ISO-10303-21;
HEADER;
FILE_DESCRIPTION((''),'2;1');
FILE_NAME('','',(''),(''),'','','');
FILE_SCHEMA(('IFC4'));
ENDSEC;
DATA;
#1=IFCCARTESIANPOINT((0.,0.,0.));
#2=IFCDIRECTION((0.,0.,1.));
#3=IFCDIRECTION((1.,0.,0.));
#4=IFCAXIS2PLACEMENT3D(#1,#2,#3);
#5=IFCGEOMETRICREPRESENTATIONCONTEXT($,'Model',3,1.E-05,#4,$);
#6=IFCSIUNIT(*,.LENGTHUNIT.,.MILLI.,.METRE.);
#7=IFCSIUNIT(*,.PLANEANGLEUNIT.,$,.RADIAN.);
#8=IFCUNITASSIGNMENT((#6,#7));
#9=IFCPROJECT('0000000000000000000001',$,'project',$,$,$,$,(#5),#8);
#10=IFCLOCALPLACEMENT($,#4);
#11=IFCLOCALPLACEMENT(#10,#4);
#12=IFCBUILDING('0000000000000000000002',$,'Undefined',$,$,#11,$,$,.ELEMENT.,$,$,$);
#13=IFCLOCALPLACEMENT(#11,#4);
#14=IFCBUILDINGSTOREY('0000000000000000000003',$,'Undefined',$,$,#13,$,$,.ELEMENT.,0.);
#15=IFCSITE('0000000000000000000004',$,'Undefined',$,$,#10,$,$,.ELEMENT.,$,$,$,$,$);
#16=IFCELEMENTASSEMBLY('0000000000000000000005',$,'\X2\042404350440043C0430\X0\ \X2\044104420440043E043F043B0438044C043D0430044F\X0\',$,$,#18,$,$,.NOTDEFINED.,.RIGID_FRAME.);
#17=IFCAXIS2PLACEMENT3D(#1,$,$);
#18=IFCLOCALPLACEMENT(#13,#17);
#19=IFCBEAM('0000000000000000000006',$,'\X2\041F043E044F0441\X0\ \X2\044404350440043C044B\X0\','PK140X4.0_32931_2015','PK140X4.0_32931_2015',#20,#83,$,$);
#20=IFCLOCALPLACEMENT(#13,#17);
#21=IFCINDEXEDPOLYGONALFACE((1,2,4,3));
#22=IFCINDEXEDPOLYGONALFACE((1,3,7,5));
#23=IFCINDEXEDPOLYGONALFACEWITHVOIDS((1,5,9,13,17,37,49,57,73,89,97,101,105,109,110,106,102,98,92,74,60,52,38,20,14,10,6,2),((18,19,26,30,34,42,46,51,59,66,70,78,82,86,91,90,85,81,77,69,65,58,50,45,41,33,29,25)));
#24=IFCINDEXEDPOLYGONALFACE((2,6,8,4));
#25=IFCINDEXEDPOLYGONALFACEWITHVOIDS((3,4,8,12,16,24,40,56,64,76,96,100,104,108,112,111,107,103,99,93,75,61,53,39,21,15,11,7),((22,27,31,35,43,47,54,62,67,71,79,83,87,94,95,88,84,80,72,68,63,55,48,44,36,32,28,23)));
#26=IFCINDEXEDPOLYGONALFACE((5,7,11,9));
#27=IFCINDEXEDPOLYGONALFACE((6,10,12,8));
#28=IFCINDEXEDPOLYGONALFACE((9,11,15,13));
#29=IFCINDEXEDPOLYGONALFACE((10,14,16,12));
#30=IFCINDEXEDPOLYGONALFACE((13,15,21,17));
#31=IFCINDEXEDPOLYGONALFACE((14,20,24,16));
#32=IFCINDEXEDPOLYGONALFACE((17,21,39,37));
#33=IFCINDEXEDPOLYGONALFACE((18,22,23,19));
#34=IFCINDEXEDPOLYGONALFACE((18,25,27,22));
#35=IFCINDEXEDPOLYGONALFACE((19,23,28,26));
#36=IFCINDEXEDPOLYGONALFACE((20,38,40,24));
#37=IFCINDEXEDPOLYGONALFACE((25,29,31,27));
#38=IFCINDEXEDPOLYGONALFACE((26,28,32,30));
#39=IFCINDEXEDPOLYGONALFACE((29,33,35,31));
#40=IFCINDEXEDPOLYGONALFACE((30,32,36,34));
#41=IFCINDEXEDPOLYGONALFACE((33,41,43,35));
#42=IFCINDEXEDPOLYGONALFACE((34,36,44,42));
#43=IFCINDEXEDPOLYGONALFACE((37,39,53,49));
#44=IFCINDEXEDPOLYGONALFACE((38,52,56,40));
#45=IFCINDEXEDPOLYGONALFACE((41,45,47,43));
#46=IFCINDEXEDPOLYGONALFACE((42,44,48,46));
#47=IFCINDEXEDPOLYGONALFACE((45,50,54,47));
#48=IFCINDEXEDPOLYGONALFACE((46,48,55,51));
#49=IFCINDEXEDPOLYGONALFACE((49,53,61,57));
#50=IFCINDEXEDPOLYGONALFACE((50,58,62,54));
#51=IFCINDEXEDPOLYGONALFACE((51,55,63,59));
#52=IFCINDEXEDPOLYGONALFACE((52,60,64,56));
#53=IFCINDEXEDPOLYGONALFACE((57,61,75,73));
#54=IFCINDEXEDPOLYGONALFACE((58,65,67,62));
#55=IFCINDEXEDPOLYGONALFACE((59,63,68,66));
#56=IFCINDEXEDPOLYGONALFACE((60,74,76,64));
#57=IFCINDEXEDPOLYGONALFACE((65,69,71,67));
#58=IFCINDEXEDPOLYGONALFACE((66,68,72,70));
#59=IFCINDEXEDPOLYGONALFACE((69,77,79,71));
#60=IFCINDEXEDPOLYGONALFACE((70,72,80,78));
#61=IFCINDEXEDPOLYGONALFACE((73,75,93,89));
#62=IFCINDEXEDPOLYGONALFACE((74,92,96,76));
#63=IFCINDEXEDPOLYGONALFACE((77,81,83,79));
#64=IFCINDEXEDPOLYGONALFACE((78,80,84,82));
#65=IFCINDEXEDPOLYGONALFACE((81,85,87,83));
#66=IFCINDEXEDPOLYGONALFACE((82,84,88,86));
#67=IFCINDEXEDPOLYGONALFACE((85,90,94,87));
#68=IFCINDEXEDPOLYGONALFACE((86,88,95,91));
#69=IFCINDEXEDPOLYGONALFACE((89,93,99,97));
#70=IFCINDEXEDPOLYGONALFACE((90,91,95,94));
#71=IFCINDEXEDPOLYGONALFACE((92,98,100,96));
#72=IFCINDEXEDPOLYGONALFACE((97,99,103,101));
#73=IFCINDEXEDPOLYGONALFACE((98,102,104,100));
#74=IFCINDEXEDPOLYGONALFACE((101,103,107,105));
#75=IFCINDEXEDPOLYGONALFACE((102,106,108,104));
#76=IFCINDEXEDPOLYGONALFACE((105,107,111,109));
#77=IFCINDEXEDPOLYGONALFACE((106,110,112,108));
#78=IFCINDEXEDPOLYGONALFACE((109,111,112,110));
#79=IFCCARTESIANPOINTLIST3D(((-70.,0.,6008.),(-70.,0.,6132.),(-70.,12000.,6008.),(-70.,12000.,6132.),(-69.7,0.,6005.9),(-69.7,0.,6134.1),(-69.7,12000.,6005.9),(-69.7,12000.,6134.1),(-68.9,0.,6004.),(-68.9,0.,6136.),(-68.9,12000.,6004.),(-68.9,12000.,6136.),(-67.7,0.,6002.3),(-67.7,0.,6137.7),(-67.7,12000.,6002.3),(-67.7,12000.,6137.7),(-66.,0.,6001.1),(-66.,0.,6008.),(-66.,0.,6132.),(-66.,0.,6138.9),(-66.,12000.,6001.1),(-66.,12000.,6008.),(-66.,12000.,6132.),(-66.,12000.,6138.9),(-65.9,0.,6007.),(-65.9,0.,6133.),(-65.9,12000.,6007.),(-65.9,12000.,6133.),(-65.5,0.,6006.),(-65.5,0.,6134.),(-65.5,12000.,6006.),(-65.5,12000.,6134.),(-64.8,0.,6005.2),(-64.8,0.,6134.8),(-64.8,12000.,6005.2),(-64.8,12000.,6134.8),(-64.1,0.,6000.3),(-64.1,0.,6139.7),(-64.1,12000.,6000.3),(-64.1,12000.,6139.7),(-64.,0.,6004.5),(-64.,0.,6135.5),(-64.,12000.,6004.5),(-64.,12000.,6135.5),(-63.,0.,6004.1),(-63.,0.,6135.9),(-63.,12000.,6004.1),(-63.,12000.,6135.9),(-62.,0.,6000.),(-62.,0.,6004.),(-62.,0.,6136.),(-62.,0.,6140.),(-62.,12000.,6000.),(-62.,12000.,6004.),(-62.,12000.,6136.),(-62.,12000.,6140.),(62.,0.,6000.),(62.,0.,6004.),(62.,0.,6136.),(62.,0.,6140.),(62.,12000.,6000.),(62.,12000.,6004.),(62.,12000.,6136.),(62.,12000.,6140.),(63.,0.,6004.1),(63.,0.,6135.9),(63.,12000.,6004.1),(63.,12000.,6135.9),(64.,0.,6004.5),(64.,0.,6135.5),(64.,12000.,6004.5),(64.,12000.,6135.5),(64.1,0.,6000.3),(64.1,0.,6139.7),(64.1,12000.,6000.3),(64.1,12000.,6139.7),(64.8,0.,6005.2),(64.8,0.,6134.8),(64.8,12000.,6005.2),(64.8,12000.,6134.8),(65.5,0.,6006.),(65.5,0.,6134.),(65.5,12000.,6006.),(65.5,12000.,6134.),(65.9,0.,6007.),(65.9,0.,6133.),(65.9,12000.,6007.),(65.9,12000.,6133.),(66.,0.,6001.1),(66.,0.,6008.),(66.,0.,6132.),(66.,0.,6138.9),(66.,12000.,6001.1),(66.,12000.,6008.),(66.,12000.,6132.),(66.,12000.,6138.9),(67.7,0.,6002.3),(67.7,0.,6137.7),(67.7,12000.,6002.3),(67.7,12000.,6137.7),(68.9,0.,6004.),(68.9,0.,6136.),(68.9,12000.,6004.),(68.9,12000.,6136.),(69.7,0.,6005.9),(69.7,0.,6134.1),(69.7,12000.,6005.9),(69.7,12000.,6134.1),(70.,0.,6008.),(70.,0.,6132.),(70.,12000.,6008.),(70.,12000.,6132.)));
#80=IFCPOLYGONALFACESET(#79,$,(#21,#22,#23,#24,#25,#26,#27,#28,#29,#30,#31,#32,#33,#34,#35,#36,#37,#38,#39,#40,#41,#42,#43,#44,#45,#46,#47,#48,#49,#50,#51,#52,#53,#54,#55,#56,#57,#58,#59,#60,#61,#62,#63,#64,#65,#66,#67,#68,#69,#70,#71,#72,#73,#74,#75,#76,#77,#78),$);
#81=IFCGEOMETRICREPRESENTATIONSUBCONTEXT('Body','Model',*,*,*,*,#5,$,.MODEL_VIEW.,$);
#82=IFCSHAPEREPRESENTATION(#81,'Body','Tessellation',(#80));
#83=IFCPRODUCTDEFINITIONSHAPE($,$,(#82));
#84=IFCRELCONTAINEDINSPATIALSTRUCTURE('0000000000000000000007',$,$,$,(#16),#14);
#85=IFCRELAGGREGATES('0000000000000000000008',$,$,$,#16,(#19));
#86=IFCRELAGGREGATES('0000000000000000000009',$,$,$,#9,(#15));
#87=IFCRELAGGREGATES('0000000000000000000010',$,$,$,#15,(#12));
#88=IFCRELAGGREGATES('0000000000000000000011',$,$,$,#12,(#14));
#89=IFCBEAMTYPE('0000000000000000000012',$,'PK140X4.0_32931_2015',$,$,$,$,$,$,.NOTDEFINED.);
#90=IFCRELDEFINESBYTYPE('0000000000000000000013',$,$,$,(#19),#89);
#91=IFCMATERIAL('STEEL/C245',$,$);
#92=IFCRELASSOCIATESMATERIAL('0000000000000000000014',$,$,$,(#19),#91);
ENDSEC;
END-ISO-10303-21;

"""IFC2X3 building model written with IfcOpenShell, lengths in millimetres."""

from ifc_helpers import new_model, si_unit, frame, origin_with_axes, origin_2d_with_axis, place, context, subcontext, project, spatial, hollow_rectangle, extrude, material, type_object, element, aggregate, save


model = new_model("IFC2X3")

# Units and contexts
model_context = context("Model", 3, precision=1e-05, world=origin_with_axes())
body_context = subcontext(model_context, "Body", "Model", "MODEL_VIEW")
ifc_project = project(units=[si_unit("LENGTHUNIT", "METRE", prefix="MILLI"), si_unit("PLANEANGLEUNIT", "RADIAN")], contexts=[model_context])

# Site, building, storey
site_placement = place(None, origin_with_axes())
site = spatial("IfcSite", under=ifc_project, at=site_placement, Name="Undefined", CompositionType="ELEMENT")
building_placement = place(site_placement, origin_with_axes())
building = spatial("IfcBuilding", under=site, at=building_placement, Name="Undefined", CompositionType="ELEMENT")
storey_placement = place(building_placement, origin_with_axes())
storey = spatial("IfcBuildingStorey", under=building, at=storey_placement, Name="Undefined", CompositionType="ELEMENT", Elevation=0.0)

# Shared definitions
ifc_material = material(Name="STEEL/C245")

# Element assembly
assembly_1_placement = place(storey_placement, origin_with_axes())
assembly_1 = element("IfcElementAssembly", 1, at=assembly_1_placement, inside=storey, Name="Ферма строплиьная", AssemblyPlace="NOTDEFINED", PredefinedType="RIGID_FRAME")

# Beam
beam_type_1 = type_object("IfcBeamType", Name="PK140X4.0_32931_2015", PredefinedType="NOTDEFINED")
beam_1_placement = place(assembly_1_placement, frame((0.0, 0.0, 6070.0), z_axis=(0.0, 0.0, 1.0), x_axis=(0.0, 1.0, 0.0)))
beam_1 = element("IfcBeam", 2, at=beam_1_placement, type_object=beam_type_1, material=ifc_material, Name="Пояс фермы", Description="PK140X4.0_32931_2015", ObjectType="PK140X4.0_32931_2015", context=body_context, shape_type="SweptSolid", body=[
    extrude(hollow_rectangle(XDim=140.0, YDim=140.0, WallThickness=4.0, InnerFilletRadius=4.0, OuterFilletRadius=8.0, at=origin_2d_with_axis()), frame((12000.0, 0.0, 0.0), z_axis=(-1.0, 0.0, 0.0), x_axis=(0.0, -1.0, 0.0)), (0.0, 0.0, 1.0), 12000.0),
])
aggregate(assembly_1, [beam_1])

save(model, "model.ifc")
